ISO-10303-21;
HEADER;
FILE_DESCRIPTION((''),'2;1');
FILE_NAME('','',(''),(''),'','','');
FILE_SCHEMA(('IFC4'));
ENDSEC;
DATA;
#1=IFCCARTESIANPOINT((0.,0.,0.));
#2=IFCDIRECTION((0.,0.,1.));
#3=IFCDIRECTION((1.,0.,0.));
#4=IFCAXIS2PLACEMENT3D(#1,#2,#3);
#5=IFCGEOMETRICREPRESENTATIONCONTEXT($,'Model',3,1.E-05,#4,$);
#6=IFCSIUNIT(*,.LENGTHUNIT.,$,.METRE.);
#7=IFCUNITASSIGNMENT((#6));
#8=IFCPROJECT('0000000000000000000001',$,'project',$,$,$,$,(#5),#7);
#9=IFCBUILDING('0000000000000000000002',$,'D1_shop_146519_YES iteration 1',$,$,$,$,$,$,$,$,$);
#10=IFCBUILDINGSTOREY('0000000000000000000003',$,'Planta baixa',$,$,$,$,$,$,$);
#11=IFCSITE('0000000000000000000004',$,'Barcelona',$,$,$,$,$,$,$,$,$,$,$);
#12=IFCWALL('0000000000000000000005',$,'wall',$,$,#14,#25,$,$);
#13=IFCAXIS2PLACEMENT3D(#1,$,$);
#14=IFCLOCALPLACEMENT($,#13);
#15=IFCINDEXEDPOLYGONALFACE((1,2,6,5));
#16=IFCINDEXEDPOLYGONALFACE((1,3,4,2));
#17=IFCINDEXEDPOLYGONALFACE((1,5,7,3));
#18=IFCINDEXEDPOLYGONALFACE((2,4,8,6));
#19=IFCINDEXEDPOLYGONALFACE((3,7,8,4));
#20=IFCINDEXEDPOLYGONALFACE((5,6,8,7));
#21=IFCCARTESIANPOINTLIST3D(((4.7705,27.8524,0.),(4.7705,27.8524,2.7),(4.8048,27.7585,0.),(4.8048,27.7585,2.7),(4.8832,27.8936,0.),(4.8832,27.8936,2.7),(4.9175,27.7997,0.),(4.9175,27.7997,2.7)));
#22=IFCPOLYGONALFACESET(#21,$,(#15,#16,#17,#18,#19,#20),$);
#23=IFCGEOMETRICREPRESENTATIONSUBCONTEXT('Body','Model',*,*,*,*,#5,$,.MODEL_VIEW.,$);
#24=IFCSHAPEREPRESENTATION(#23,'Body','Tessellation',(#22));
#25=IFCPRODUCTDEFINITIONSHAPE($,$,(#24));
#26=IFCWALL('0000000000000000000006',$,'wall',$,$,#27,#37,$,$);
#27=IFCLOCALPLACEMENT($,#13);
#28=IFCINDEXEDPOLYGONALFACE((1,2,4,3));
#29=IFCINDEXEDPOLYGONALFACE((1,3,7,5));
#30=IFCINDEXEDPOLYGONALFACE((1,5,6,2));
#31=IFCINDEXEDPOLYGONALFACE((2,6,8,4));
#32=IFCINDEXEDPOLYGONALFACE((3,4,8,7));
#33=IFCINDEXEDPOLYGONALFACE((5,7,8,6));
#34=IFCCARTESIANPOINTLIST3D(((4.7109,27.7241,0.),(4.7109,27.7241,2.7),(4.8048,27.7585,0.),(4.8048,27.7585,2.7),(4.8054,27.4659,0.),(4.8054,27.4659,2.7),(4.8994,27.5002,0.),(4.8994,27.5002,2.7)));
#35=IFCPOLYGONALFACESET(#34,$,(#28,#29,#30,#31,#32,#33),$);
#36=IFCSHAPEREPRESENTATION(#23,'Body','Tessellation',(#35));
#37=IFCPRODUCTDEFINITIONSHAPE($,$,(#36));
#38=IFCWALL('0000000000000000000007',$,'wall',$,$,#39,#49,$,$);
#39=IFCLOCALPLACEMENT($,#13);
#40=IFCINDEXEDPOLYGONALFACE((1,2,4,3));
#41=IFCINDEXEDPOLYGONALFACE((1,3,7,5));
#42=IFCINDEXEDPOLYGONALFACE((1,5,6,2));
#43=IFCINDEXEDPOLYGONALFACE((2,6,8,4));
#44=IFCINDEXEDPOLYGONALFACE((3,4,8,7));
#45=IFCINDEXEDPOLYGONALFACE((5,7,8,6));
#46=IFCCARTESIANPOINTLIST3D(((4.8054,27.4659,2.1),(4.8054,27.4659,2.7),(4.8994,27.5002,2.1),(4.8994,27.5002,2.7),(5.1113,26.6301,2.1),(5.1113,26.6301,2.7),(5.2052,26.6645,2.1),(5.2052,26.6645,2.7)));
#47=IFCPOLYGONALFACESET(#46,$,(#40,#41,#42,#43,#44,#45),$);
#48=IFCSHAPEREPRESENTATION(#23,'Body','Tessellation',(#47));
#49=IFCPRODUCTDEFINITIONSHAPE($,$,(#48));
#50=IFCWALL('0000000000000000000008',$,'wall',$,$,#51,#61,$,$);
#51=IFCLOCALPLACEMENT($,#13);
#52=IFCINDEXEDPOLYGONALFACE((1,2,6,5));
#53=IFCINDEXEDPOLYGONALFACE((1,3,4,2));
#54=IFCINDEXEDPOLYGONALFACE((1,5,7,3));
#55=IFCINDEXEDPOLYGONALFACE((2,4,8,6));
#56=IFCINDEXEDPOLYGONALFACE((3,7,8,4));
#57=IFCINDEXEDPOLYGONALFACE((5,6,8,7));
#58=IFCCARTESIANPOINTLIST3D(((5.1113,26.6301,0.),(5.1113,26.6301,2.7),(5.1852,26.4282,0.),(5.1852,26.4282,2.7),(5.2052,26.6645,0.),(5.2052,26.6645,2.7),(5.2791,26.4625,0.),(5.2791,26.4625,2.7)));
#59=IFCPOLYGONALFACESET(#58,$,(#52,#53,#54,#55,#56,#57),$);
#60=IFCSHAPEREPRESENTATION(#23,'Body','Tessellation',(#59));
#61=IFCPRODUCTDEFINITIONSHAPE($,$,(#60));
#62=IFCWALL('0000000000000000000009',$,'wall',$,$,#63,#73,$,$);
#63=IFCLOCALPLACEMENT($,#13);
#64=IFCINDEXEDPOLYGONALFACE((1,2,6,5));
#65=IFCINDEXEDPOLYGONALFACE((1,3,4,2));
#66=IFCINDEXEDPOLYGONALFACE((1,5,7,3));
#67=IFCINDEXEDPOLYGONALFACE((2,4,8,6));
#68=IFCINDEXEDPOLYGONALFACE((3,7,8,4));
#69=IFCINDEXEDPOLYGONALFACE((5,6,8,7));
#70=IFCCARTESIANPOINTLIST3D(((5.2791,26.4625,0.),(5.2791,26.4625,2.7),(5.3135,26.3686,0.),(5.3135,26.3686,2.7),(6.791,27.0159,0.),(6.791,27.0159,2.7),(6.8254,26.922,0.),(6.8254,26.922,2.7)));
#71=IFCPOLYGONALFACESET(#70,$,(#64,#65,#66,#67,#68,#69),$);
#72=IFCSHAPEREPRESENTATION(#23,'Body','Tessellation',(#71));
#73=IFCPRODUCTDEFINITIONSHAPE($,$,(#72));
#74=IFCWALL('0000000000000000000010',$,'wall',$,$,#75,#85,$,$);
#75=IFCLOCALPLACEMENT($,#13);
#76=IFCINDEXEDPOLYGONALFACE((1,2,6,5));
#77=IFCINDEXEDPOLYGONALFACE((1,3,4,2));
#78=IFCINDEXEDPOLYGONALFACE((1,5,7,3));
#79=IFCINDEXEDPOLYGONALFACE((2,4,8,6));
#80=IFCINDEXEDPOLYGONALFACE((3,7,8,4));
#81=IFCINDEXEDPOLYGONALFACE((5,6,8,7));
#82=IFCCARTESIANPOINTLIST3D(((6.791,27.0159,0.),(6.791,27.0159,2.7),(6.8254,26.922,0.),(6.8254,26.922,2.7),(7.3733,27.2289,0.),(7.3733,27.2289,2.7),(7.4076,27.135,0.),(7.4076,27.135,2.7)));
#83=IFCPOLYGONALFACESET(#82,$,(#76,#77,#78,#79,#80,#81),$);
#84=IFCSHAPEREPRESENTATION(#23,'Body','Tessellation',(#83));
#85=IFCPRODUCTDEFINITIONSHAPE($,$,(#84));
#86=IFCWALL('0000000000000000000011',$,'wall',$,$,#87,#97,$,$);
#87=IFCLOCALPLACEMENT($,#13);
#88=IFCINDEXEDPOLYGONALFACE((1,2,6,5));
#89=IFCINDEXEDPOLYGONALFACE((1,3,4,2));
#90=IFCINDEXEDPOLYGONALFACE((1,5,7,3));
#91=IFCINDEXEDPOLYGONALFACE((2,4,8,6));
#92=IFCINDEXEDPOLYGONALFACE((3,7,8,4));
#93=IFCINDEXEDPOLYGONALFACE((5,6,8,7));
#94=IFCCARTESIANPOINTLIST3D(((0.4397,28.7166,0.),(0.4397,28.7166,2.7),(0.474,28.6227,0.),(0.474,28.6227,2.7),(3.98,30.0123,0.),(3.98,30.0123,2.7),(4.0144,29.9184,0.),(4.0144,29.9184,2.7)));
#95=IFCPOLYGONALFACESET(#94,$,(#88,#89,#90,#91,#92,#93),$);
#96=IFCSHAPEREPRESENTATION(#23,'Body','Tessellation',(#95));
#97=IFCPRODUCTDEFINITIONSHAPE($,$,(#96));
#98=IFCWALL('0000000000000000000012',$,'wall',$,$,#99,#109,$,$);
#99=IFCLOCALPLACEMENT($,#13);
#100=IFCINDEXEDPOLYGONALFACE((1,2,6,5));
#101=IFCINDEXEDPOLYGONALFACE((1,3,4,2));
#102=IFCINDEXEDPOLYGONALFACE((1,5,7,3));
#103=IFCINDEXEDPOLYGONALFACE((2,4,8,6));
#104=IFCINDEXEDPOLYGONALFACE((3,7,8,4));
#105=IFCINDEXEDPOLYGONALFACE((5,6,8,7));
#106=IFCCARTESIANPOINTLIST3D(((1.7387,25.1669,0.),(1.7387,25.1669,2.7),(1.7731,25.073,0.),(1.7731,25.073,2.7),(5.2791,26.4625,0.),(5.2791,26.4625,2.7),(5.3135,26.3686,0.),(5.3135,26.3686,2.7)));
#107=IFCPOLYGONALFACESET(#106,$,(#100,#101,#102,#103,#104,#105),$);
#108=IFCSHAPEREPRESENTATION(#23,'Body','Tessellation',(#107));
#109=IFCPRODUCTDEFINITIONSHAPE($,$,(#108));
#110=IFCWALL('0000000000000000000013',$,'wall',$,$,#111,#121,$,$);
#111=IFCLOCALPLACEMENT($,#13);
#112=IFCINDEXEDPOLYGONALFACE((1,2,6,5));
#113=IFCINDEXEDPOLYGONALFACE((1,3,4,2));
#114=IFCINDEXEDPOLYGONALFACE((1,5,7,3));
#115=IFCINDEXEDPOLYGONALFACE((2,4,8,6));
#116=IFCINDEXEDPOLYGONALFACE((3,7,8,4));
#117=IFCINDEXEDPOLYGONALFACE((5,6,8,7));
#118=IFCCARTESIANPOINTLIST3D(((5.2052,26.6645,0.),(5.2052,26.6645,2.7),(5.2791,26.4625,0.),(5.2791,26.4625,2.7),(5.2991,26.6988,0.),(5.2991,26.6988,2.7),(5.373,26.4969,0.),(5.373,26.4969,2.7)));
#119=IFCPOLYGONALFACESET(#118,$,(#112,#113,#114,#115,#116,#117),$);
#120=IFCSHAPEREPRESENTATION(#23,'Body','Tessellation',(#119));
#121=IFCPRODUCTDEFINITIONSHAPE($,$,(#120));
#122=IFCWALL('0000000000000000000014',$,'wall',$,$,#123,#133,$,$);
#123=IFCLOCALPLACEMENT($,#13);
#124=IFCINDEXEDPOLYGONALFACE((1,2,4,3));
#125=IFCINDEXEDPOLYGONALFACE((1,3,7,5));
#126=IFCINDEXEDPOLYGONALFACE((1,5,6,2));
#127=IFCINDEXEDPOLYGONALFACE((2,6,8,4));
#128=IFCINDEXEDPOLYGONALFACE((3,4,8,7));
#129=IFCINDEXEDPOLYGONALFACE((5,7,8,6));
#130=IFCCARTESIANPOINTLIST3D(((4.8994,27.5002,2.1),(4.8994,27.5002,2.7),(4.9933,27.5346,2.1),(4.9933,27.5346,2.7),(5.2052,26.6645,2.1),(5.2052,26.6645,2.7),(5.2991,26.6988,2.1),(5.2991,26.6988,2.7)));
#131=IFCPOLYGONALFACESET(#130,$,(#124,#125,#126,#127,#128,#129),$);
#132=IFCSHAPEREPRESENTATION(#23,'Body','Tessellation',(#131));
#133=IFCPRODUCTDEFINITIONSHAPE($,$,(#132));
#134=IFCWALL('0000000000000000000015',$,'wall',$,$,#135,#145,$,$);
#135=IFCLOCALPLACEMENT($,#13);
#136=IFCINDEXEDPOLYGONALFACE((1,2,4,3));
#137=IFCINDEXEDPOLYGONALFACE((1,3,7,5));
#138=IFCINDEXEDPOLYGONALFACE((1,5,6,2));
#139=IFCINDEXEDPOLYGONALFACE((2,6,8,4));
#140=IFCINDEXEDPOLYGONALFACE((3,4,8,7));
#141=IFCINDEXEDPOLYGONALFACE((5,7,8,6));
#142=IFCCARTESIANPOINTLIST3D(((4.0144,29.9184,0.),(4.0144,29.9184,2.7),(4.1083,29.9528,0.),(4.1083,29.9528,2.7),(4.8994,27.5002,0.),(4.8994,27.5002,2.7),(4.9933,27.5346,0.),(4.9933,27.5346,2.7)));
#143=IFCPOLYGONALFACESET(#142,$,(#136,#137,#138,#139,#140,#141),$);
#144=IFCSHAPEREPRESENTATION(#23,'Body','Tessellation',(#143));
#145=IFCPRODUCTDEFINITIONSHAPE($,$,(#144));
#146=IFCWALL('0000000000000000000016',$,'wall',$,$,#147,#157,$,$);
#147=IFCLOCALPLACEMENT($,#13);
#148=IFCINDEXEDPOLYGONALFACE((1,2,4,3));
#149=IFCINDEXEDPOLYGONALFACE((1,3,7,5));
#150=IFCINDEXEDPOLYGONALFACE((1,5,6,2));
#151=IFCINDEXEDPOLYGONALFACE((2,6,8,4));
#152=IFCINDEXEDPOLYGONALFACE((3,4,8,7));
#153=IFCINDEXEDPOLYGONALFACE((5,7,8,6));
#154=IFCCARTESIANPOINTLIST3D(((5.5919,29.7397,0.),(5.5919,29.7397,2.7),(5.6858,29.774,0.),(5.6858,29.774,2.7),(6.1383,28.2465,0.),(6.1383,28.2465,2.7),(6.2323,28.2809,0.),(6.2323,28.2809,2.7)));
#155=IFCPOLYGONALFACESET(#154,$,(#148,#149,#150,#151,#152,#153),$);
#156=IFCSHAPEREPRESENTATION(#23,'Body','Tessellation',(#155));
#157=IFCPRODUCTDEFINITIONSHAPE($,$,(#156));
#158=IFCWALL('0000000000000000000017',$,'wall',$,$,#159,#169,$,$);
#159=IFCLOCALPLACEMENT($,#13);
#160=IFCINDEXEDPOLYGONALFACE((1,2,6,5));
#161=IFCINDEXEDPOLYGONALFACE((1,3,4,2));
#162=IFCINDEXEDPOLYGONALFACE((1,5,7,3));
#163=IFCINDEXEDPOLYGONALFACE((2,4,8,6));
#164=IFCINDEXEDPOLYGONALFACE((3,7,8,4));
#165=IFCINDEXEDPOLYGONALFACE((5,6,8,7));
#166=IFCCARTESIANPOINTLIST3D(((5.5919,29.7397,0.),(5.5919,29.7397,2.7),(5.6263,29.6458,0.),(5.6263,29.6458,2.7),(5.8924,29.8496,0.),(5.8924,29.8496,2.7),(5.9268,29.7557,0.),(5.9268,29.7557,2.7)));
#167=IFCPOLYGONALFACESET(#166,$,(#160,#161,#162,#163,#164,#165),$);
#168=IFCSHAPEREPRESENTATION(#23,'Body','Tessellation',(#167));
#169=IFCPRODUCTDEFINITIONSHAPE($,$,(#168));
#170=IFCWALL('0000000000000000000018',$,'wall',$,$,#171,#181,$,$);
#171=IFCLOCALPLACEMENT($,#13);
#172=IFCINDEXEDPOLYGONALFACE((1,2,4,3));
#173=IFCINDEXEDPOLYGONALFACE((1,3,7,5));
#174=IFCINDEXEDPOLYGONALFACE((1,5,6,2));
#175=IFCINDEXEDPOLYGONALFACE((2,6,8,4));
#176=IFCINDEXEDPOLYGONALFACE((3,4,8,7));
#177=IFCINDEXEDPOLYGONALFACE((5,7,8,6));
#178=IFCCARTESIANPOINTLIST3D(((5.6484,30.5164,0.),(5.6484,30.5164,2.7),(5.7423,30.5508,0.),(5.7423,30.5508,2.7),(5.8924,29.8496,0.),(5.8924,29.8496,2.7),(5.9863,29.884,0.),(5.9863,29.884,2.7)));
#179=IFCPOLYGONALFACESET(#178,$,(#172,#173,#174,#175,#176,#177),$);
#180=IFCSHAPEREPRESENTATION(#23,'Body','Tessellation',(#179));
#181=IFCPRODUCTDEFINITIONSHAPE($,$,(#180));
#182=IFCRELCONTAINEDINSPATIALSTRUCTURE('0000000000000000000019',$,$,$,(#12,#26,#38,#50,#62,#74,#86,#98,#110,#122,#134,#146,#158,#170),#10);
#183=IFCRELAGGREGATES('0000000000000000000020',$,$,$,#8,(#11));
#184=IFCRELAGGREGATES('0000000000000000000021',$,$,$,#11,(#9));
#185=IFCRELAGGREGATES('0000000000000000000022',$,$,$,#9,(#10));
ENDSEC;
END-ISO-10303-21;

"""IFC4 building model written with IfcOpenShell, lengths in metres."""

from ifc_helpers import new_model, si_unit, frame, origin, origin_with_axes, place, context, subcontext, project, spatial, polyline, outline, extrude, element, save


model = new_model("IFC4")

# Units and contexts
model_context = context("Model", 3, precision=1e-05, world=origin_with_axes())
body_context = subcontext(model_context, "Body", "Model", "MODEL_VIEW")
ifc_project = project(units=[si_unit("LENGTHUNIT", "METRE")], contexts=[model_context])

# Site, building, storey
site = spatial("IfcSite", under=ifc_project, Name="Barcelona")
building = spatial("IfcBuilding", under=site, Name="D1_shop_146519_YES iteration 1")
storey = spatial("IfcBuildingStorey", under=building, Name="Planta baixa")

# Walls
wall_1_placement = place(None, origin_with_axes())
element("IfcWall", 1, at=wall_1_placement, inside=storey, Name="wall", context=body_context, shape_type="SweptSolid", body=[
    extrude(outline(polyline([(4.9175, 27.7997), (4.8048, 27.7585), (4.7705, 27.8524), (4.8832, 27.8936), (4.9175, 27.7997)])), origin(), (0.0, 0.0, 1.0), 2.7),
])
wall_2_placement = place(None, origin_with_axes())
element("IfcWall", 2, at=wall_2_placement, inside=storey, Name="wall", context=body_context, shape_type="SweptSolid", body=[
    extrude(outline(polyline([(4.8048, 27.7585), (4.8994, 27.5002), (4.8054, 27.4659), (4.7109, 27.7241), (4.8048, 27.7585)])), origin(), (0.0, 0.0, 1.0), 2.7),
])
wall_3_placement = place(None, origin_with_axes())
element("IfcWall", 3, at=wall_3_placement, inside=storey, Name="wall", context=body_context, shape_type="SweptSolid", body=[
    extrude(outline(polyline([(4.8994, 27.5002), (5.2052, 26.6645), (5.1113, 26.6301), (4.8054, 27.4659), (4.8994, 27.5002)])), frame((0.0, 0.0, 2.1)), (0.0, 0.0, 1.0), 0.6),
])
wall_4_placement = place(None, origin_with_axes())
element("IfcWall", 4, at=wall_4_placement, inside=storey, Name="wall", context=body_context, shape_type="SweptSolid", body=[
    extrude(outline(polyline([(5.2052, 26.6645), (5.2791, 26.4625), (5.1852, 26.4282), (5.1113, 26.6301), (5.2052, 26.6645)])), origin(), (0.0, 0.0, 1.0), 2.7),
])
wall_5_placement = place(None, origin_with_axes())
element("IfcWall", 5, at=wall_5_placement, inside=storey, Name="wall", context=body_context, shape_type="SweptSolid", body=[
    extrude(outline(polyline([(5.2791, 26.4625), (6.791, 27.0159), (6.8254, 26.922), (5.3135, 26.3686), (5.2791, 26.4625)])), origin(), (0.0, 0.0, 1.0), 2.7),
])
wall_6_placement = place(None, origin_with_axes())
element("IfcWall", 6, at=wall_6_placement, inside=storey, Name="wall", context=body_context, shape_type="SweptSolid", body=[
    extrude(outline(polyline([(6.791, 27.0159), (7.3733, 27.2289), (7.4076, 27.135), (6.8254, 26.922), (6.791, 27.0159)])), origin(), (0.0, 0.0, 1.0), 2.7),
])
wall_7_placement = place(None, origin_with_axes())
element("IfcWall", 7, at=wall_7_placement, inside=storey, Name="wall", context=body_context, shape_type="SweptSolid", body=[
    extrude(outline(polyline([(4.0144, 29.9184), (0.474, 28.6227), (0.4397, 28.7166), (3.98, 30.0123), (4.0144, 29.9184)])), origin(), (0.0, 0.0, 1.0), 2.7),
])
wall_8_placement = place(None, origin_with_axes())
element("IfcWall", 8, at=wall_8_placement, inside=storey, Name="wall", context=body_context, shape_type="SweptSolid", body=[
    extrude(outline(polyline([(1.7387, 25.1669), (5.2791, 26.4625), (5.3135, 26.3686), (1.7731, 25.073), (1.7387, 25.1669)])), origin(), (0.0, 0.0, 1.0), 2.7),
])
wall_9_placement = place(None, origin_with_axes())
element("IfcWall", 9, at=wall_9_placement, inside=storey, Name="wall", context=body_context, shape_type="SweptSolid", body=[
    extrude(outline(polyline([(5.2791, 26.4625), (5.2052, 26.6645), (5.2991, 26.6988), (5.373, 26.4969), (5.2791, 26.4625)])), origin(), (0.0, 0.0, 1.0), 2.7),
])
wall_10_placement = place(None, origin_with_axes())
element("IfcWall", 10, at=wall_10_placement, inside=storey, Name="wall", context=body_context, shape_type="SweptSolid", body=[
    extrude(outline(polyline([(5.2052, 26.6645), (4.8994, 27.5002), (4.9933, 27.5346), (5.2991, 26.6988), (5.2052, 26.6645)])), frame((0.0, 0.0, 2.1)), (0.0, 0.0, 1.0), 0.6),
])
wall_11_placement = place(None, origin_with_axes())
element("IfcWall", 11, at=wall_11_placement, inside=storey, Name="wall", context=body_context, shape_type="SweptSolid", body=[
    extrude(outline(polyline([(4.8994, 27.5002), (4.0144, 29.9184), (4.1083, 29.9528), (4.9933, 27.5346), (4.8994, 27.5002)])), origin(), (0.0, 0.0, 1.0), 2.7),
])
wall_12_placement = place(None, origin_with_axes())
element("IfcWall", 12, at=wall_12_placement, inside=storey, Name="wall", context=body_context, shape_type="SweptSolid", body=[
    extrude(outline(polyline([(6.1383, 28.2465), (5.5919, 29.7397), (5.6858, 29.774), (6.2323, 28.2809), (6.1383, 28.2465)])), origin(), (0.0, 0.0, 1.0), 2.7),
])
wall_13_placement = place(None, origin_with_axes())
element("IfcWall", 13, at=wall_13_placement, inside=storey, Name="wall", context=body_context, shape_type="SweptSolid", body=[
    extrude(outline(polyline([(5.5919, 29.7397), (5.8924, 29.8496), (5.9268, 29.7557), (5.6263, 29.6458), (5.5919, 29.7397)])), origin(), (0.0, 0.0, 1.0), 2.7),
])
wall_14_placement = place(None, origin_with_axes())
element("IfcWall", 14, at=wall_14_placement, inside=storey, Name="wall", context=body_context, shape_type="SweptSolid", body=[
    extrude(outline(polyline([(5.8924, 29.8496), (5.6484, 30.5164), (5.7423, 30.5508), (5.9863, 29.884), (5.8924, 29.8496)])), origin(), (0.0, 0.0, 1.0), 2.7),
])

save(model, "model.ifc")
